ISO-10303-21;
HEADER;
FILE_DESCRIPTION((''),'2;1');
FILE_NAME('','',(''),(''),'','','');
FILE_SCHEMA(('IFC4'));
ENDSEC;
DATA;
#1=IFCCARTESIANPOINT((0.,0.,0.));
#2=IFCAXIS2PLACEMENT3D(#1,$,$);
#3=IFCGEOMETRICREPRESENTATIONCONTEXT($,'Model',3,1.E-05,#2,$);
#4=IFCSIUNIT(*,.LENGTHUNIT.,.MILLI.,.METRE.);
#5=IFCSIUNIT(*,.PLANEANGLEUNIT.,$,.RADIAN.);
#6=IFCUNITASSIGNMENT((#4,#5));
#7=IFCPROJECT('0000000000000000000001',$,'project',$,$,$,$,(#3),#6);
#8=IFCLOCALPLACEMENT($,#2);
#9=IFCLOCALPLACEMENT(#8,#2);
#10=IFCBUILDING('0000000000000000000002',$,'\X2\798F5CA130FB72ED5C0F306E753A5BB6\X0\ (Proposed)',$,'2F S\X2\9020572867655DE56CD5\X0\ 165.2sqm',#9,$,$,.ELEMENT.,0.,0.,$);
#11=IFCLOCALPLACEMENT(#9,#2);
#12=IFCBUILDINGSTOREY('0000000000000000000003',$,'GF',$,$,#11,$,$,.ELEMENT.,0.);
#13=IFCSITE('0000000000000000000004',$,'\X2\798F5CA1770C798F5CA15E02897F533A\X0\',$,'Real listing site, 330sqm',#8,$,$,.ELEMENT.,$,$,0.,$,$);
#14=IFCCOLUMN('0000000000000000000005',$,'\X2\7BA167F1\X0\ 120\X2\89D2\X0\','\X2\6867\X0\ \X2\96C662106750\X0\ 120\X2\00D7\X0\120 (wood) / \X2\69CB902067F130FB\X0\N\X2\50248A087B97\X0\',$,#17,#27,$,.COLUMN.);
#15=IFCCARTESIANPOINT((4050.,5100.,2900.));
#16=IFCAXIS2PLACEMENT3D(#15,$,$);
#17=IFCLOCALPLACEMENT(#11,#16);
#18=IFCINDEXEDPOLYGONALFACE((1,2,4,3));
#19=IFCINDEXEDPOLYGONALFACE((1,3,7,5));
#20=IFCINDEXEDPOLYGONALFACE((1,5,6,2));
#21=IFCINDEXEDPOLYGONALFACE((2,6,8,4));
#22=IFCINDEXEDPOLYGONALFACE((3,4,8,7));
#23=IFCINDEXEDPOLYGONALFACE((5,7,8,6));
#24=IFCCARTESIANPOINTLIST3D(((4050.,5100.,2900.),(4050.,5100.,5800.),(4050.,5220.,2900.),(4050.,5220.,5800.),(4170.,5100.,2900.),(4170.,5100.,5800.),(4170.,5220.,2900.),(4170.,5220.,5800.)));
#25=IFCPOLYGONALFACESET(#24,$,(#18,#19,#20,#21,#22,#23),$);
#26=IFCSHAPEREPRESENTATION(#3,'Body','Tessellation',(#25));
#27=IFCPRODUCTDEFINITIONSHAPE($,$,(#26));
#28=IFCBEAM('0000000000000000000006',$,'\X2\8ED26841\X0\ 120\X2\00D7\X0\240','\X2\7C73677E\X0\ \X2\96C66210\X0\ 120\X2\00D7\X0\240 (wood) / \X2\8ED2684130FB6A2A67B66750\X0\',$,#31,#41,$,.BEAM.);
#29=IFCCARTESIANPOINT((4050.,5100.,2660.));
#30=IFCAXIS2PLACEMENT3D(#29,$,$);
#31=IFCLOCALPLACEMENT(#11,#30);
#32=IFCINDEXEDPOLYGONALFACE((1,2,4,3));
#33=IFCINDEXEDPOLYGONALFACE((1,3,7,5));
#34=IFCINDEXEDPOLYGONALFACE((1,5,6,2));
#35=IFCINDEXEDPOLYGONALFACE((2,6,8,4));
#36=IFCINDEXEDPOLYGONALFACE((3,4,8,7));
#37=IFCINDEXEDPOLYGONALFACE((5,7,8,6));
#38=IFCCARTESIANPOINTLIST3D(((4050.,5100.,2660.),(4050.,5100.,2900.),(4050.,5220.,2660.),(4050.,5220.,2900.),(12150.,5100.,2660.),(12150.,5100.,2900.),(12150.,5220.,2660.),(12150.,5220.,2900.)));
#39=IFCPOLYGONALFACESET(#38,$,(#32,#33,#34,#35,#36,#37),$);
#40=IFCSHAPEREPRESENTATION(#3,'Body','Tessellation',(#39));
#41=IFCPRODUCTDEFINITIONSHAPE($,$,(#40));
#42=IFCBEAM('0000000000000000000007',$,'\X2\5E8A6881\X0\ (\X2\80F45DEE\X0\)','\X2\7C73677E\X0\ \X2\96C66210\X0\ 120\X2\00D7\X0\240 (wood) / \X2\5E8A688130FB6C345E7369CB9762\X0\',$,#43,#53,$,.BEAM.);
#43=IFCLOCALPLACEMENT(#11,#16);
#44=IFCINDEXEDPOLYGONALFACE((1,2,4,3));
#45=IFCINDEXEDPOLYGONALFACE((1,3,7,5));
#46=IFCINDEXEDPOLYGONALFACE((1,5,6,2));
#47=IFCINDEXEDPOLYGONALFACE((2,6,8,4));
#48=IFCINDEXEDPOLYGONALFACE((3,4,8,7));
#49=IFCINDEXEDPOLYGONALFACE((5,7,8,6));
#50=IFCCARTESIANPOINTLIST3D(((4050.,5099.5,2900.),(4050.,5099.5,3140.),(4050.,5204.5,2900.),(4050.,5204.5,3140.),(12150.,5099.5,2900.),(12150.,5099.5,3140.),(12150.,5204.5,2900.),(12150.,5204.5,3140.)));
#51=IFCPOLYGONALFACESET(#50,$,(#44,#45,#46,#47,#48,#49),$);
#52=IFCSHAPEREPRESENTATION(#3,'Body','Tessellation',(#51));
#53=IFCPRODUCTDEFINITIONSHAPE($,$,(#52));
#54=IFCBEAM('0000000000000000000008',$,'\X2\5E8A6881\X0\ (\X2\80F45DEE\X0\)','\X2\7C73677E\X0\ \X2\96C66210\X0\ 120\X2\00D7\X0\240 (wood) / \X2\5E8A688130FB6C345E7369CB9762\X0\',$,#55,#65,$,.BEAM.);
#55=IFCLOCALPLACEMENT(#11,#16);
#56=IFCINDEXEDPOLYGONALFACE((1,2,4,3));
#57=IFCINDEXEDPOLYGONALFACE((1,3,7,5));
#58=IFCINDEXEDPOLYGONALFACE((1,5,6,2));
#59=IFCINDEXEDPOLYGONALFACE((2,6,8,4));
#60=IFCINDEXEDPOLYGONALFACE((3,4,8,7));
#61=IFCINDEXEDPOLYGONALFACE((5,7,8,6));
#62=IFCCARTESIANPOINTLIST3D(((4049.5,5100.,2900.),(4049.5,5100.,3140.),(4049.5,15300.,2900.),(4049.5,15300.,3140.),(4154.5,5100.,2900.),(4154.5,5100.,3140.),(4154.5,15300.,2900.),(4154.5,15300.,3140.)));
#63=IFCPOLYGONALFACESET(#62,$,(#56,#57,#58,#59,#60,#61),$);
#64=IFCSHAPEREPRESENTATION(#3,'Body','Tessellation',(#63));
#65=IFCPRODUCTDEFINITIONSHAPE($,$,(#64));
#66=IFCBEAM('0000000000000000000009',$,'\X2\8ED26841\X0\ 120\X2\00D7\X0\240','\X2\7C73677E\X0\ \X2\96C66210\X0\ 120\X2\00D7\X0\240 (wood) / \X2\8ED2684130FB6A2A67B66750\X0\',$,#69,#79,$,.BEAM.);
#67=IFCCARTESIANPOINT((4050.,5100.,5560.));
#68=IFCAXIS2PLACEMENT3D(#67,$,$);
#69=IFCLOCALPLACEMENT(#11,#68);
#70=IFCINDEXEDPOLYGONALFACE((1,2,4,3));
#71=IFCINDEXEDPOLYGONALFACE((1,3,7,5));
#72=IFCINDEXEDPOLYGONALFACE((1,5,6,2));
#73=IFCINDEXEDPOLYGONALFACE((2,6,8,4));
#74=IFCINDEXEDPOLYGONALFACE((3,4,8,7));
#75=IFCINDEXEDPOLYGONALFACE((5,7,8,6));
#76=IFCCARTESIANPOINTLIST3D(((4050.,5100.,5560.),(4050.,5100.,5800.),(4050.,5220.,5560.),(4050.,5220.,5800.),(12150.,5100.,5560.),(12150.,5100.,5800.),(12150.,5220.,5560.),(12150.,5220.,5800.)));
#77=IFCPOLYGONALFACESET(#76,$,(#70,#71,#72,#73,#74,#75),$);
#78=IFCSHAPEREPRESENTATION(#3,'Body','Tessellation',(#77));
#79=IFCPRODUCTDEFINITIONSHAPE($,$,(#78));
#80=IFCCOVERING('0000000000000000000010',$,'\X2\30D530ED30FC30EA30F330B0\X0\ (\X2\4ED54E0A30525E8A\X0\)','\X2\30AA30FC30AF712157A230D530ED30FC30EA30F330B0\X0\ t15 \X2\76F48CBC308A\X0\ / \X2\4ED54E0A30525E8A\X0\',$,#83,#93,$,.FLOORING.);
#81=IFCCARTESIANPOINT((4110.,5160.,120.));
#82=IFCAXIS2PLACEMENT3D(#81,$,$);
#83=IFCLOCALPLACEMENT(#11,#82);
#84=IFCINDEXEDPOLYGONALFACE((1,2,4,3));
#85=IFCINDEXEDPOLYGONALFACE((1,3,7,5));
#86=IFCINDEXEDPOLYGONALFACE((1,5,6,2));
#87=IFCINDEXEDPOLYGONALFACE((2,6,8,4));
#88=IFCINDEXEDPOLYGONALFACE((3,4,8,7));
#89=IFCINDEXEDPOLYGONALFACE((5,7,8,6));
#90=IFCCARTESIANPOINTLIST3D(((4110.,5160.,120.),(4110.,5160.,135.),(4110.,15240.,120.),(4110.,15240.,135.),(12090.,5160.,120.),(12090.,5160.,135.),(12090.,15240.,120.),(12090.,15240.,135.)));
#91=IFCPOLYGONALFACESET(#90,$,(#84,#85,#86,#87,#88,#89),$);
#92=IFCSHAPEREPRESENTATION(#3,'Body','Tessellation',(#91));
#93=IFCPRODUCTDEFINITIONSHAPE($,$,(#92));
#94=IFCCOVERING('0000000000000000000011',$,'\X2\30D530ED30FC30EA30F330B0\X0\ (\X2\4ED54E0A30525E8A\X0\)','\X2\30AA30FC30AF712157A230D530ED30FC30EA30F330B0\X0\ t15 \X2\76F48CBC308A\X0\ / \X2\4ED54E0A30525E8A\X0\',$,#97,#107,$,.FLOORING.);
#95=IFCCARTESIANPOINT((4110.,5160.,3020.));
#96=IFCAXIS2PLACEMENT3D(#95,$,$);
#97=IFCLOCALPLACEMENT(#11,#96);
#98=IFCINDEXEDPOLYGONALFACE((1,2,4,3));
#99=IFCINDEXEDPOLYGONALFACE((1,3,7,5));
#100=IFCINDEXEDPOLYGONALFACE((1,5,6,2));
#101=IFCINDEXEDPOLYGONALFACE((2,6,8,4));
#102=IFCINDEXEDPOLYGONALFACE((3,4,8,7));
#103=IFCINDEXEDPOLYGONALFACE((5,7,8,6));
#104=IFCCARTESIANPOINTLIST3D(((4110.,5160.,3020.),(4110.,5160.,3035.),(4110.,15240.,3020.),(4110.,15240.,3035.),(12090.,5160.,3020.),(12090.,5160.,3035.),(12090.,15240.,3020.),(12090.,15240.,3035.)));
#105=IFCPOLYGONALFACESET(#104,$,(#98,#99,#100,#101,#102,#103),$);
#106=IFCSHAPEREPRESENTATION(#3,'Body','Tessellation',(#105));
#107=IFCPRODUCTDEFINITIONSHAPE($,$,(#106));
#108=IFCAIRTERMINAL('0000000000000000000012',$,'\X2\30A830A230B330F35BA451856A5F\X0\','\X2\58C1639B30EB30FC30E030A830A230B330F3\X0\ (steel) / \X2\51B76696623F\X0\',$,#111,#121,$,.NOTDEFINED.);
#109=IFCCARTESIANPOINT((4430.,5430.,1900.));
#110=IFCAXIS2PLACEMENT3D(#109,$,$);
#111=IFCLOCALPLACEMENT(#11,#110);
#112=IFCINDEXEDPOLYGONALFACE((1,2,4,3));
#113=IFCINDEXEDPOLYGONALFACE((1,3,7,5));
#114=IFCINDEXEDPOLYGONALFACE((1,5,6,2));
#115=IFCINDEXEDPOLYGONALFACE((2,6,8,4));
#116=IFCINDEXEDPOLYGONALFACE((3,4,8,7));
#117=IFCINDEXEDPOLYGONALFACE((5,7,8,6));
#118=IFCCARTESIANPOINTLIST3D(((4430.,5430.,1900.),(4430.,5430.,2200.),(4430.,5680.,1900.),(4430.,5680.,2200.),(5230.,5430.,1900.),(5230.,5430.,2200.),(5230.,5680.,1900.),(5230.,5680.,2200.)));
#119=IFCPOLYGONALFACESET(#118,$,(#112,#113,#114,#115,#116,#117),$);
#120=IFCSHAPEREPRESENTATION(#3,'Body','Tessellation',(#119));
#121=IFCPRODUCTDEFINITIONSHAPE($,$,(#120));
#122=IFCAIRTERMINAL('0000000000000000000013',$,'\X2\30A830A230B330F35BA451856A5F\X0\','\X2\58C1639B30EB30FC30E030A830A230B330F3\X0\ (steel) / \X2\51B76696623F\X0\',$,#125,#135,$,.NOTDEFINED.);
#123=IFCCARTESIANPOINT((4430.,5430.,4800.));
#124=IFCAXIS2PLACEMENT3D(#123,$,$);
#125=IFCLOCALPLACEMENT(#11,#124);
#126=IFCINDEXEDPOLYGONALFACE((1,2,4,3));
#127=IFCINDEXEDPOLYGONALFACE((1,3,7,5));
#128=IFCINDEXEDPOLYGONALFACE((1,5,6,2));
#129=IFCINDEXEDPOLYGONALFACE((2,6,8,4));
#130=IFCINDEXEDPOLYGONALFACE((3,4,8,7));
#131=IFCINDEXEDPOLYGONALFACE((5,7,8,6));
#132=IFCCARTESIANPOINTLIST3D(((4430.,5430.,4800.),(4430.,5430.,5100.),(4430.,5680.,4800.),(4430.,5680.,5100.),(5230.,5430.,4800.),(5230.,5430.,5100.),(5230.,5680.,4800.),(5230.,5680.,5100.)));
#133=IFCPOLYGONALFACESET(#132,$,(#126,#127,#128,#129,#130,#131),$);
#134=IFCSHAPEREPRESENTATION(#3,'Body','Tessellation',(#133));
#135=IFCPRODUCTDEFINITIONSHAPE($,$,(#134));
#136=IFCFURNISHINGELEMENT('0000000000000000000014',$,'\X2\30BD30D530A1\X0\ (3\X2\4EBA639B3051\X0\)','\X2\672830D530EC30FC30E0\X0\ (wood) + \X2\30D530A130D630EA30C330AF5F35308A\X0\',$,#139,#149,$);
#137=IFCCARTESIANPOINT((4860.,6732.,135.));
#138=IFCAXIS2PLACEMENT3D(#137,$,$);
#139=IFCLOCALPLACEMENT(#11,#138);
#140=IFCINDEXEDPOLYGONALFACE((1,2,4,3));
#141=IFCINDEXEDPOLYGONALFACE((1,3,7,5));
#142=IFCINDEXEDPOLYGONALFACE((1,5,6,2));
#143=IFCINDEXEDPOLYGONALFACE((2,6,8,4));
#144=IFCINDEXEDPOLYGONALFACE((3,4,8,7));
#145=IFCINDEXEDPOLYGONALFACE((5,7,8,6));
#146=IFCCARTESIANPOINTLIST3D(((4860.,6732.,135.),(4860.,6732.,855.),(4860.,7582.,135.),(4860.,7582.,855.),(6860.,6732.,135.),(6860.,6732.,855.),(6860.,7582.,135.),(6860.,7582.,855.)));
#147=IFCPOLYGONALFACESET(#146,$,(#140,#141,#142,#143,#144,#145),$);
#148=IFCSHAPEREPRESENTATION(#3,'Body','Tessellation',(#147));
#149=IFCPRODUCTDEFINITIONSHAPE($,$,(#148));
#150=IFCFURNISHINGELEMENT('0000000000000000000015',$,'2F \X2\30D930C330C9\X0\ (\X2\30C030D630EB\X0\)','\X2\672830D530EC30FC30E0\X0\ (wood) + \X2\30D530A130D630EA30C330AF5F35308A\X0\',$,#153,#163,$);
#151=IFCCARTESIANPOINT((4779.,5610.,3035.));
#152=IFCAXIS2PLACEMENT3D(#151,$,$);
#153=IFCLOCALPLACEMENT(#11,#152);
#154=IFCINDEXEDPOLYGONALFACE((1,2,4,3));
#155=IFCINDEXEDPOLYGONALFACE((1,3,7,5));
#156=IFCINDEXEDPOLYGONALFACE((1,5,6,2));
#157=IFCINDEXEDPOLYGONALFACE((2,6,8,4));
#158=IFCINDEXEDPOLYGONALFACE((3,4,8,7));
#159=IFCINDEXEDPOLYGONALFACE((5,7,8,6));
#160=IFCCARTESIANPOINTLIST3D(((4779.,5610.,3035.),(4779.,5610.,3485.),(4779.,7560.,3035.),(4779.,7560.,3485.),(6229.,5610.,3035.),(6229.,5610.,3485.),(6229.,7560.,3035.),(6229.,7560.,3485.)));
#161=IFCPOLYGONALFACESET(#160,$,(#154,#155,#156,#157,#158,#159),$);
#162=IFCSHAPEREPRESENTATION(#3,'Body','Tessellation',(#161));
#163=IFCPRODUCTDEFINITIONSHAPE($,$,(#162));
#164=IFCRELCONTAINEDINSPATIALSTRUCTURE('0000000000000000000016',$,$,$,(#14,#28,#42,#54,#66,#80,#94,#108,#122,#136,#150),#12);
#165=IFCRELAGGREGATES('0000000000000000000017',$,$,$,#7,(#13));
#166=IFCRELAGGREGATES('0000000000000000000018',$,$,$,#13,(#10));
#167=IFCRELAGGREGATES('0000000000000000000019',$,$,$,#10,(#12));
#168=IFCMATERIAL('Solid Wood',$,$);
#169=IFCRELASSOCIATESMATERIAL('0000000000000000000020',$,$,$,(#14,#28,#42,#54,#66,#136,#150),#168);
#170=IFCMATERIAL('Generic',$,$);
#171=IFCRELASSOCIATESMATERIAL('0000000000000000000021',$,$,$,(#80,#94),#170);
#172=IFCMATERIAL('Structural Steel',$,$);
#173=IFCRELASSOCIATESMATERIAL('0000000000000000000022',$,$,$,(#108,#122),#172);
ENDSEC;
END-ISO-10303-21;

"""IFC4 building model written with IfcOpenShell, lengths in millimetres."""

from ifc_helpers import new_model, si_unit, frame, frame_2d, origin, place, context, project, spatial, rectangle, extrude, material, element, save


model = new_model("IFC4")

# Units and contexts
model_context = context("Model", 3, precision=1e-05, world=origin())
ifc_project = project(units=[si_unit("LENGTHUNIT", "METRE", prefix="MILLI"), si_unit("PLANEANGLEUNIT", "RADIAN")], contexts=[model_context])

# Site, building, storey
site_placement = place(None, origin())
site = spatial("IfcSite", under=ifc_project, at=site_placement, Name="福岡県福岡市西区", ObjectType="Real listing site, 330sqm", CompositionType="ELEMENT", RefElevation=0.0)
building_placement = place(site_placement, origin())
building = spatial("IfcBuilding", under=site, at=building_placement, Name="福岡・狭小の町家 (Proposed)", ObjectType="2F S造在来工法 165.2sqm", CompositionType="ELEMENT", ElevationOfRefHeight=0.0, ElevationOfTerrain=0.0)
storey_placement = place(building_placement, origin())
storey = spatial("IfcBuildingStorey", under=building, at=storey_placement, Name="GF", CompositionType="ELEMENT", Elevation=0.0)

# Column
ifc_material_1 = material(Name="Solid Wood")
column_1_placement = place(storey_placement, frame((4050.0, 5100.0, 2900.0)))
element("IfcColumn", 1, at=column_1_placement, inside=storey, material=ifc_material_1, Name="管柱 120角", Description="桧 集成材 120×120 (wood) / 構造柱・N値計算", PredefinedType="COLUMN", context=model_context, shape_type="SweptSolid", body=[
    extrude(rectangle(XDim=120.0, YDim=120.0, at=frame_2d((60.0, 60.0))), frame((4050.0, 5100.0, 2900.0)), (0.0, 0.0, 1.0), 2900.0),
])

# Beams
beam_1_placement = place(storey_placement, frame((4050.0, 5100.0, 2660.0)))
element("IfcBeam", 2, at=beam_1_placement, inside=storey, material=ifc_material_1, Name="軒桁 120×240", Description="米松 集成 120×240 (wood) / 軒桁・横架材", PredefinedType="BEAM", context=model_context, shape_type="SweptSolid", body=[
    extrude(rectangle(XDim=8100.0, YDim=120.0, at=frame_2d((4050.0, 60.0))), frame((4050.0, 5100.0, 2660.0)), (0.0, 0.0, 1.0), 240.0),
])
beam_2_placement = place(storey_placement, frame((4050.0, 5100.0, 2900.0)))
element("IfcBeam", 3, at=beam_2_placement, inside=storey, material=ifc_material_1, Name="床梁 (胴差)", Description="米松 集成 120×240 (wood) / 床梁・水平構面", PredefinedType="BEAM", context=model_context, shape_type="SweptSolid", body=[
    extrude(rectangle(XDim=8100.0, YDim=105.0, at=frame_2d((4050.0, 52.0))), frame((4050.0, 5100.0, 2900.0)), (0.0, 0.0, 1.0), 240.0),
])
beam_3_placement = place(storey_placement, frame((4050.0, 5100.0, 2900.0)))
element("IfcBeam", 4, at=beam_3_placement, inside=storey, material=ifc_material_1, Name="床梁 (胴差)", Description="米松 集成 120×240 (wood) / 床梁・水平構面", PredefinedType="BEAM", context=model_context, shape_type="SweptSolid", body=[
    extrude(rectangle(XDim=105.0, YDim=10200.0, at=frame_2d((52.0, 5100.0))), frame((4050.0, 5100.0, 2900.0)), (0.0, 0.0, 1.0), 240.0),
])
beam_4_placement = place(storey_placement, frame((4050.0, 5100.0, 5560.0)))
element("IfcBeam", 5, at=beam_4_placement, inside=storey, material=ifc_material_1, Name="軒桁 120×240", Description="米松 集成 120×240 (wood) / 軒桁・横架材", PredefinedType="BEAM", context=model_context, shape_type="SweptSolid", body=[
    extrude(rectangle(XDim=8100.0, YDim=120.0, at=frame_2d((4050.0, 60.0))), frame((4050.0, 5100.0, 5560.0)), (0.0, 0.0, 1.0), 240.0),
])

# Coverings
ifc_material_2 = material(Name="Generic")
covering_1_placement = place(storey_placement, frame((4110.0, 5160.0, 120.0)))
element("IfcCovering", 6, at=covering_1_placement, inside=storey, material=ifc_material_2, Name="フローリング (仕上げ床)", Description="オーク無垢フローリング t15 直貼り / 仕上げ床", PredefinedType="FLOORING", context=model_context, shape_type="SweptSolid", body=[
    extrude(rectangle(XDim=7980.0, YDim=10080.0, at=frame_2d((3990.0, 5040.0))), frame((4110.0, 5160.0, 120.0)), (0.0, 0.0, 1.0), 15.0),
])
covering_2_placement = place(storey_placement, frame((4110.0, 5160.0, 3020.0)))
element("IfcCovering", 7, at=covering_2_placement, inside=storey, material=ifc_material_2, Name="フローリング (仕上げ床)", Description="オーク無垢フローリング t15 直貼り / 仕上げ床", PredefinedType="FLOORING", context=model_context, shape_type="SweptSolid", body=[
    extrude(rectangle(XDim=7980.0, YDim=10080.0, at=frame_2d((3990.0, 5040.0))), frame((4110.0, 5160.0, 3020.0)), (0.0, 0.0, 1.0), 15.0),
])

# Air terminals
ifc_material_3 = material(Name="Structural Steel")
air_terminal_1_placement = place(storey_placement, frame((4430.0, 5430.0, 1900.0)))
element("IfcAirTerminal", 8, at=air_terminal_1_placement, inside=storey, material=ifc_material_3, Name="エアコン室内機", Description="壁掛ルームエアコン (steel) / 冷暖房", PredefinedType="NOTDEFINED", context=model_context, shape_type="SweptSolid", body=[
    extrude(rectangle(XDim=800.0, YDim=250.0, at=frame_2d((400.0, 125.0))), frame((4430.0, 5430.0, 1900.0)), (0.0, 0.0, 1.0), 300.0),
])
air_terminal_2_placement = place(storey_placement, frame((4430.0, 5430.0, 4800.0)))
element("IfcAirTerminal", 9, at=air_terminal_2_placement, inside=storey, material=ifc_material_3, Name="エアコン室内機", Description="壁掛ルームエアコン (steel) / 冷暖房", PredefinedType="NOTDEFINED", context=model_context, shape_type="SweptSolid", body=[
    extrude(rectangle(XDim=800.0, YDim=250.0, at=frame_2d((400.0, 125.0))), frame((4430.0, 5430.0, 4800.0)), (0.0, 0.0, 1.0), 300.0),
])

# Furnishing elements
furnishing_1_placement = place(storey_placement, frame((4860.0, 6732.0, 135.0)))
element("IfcFurnishingElement", 10, at=furnishing_1_placement, inside=storey, material=ifc_material_1, Name="ソファ (3人掛け)", Description="木フレーム (wood) + ファブリック張り", context=model_context, shape_type="SweptSolid", body=[
    extrude(rectangle(XDim=2000.0, YDim=850.0, at=frame_2d((1000.0, 425.0))), frame((4860.0, 6732.0, 135.0)), (0.0, 0.0, 1.0), 720.0),
])
furnishing_2_placement = place(storey_placement, frame((4779.0, 5610.0, 3035.0)))
element("IfcFurnishingElement", 11, at=furnishing_2_placement, inside=storey, material=ifc_material_1, Name="2F ベッド (ダブル)", Description="木フレーム (wood) + ファブリック張り", context=model_context, shape_type="SweptSolid", body=[
    extrude(rectangle(XDim=1450.0, YDim=1950.0, at=frame_2d((725.0, 975.0))), frame((4779.0, 5610.0, 3035.0)), (0.0, 0.0, 1.0), 450.0),
])

save(model, "model.ifc")
